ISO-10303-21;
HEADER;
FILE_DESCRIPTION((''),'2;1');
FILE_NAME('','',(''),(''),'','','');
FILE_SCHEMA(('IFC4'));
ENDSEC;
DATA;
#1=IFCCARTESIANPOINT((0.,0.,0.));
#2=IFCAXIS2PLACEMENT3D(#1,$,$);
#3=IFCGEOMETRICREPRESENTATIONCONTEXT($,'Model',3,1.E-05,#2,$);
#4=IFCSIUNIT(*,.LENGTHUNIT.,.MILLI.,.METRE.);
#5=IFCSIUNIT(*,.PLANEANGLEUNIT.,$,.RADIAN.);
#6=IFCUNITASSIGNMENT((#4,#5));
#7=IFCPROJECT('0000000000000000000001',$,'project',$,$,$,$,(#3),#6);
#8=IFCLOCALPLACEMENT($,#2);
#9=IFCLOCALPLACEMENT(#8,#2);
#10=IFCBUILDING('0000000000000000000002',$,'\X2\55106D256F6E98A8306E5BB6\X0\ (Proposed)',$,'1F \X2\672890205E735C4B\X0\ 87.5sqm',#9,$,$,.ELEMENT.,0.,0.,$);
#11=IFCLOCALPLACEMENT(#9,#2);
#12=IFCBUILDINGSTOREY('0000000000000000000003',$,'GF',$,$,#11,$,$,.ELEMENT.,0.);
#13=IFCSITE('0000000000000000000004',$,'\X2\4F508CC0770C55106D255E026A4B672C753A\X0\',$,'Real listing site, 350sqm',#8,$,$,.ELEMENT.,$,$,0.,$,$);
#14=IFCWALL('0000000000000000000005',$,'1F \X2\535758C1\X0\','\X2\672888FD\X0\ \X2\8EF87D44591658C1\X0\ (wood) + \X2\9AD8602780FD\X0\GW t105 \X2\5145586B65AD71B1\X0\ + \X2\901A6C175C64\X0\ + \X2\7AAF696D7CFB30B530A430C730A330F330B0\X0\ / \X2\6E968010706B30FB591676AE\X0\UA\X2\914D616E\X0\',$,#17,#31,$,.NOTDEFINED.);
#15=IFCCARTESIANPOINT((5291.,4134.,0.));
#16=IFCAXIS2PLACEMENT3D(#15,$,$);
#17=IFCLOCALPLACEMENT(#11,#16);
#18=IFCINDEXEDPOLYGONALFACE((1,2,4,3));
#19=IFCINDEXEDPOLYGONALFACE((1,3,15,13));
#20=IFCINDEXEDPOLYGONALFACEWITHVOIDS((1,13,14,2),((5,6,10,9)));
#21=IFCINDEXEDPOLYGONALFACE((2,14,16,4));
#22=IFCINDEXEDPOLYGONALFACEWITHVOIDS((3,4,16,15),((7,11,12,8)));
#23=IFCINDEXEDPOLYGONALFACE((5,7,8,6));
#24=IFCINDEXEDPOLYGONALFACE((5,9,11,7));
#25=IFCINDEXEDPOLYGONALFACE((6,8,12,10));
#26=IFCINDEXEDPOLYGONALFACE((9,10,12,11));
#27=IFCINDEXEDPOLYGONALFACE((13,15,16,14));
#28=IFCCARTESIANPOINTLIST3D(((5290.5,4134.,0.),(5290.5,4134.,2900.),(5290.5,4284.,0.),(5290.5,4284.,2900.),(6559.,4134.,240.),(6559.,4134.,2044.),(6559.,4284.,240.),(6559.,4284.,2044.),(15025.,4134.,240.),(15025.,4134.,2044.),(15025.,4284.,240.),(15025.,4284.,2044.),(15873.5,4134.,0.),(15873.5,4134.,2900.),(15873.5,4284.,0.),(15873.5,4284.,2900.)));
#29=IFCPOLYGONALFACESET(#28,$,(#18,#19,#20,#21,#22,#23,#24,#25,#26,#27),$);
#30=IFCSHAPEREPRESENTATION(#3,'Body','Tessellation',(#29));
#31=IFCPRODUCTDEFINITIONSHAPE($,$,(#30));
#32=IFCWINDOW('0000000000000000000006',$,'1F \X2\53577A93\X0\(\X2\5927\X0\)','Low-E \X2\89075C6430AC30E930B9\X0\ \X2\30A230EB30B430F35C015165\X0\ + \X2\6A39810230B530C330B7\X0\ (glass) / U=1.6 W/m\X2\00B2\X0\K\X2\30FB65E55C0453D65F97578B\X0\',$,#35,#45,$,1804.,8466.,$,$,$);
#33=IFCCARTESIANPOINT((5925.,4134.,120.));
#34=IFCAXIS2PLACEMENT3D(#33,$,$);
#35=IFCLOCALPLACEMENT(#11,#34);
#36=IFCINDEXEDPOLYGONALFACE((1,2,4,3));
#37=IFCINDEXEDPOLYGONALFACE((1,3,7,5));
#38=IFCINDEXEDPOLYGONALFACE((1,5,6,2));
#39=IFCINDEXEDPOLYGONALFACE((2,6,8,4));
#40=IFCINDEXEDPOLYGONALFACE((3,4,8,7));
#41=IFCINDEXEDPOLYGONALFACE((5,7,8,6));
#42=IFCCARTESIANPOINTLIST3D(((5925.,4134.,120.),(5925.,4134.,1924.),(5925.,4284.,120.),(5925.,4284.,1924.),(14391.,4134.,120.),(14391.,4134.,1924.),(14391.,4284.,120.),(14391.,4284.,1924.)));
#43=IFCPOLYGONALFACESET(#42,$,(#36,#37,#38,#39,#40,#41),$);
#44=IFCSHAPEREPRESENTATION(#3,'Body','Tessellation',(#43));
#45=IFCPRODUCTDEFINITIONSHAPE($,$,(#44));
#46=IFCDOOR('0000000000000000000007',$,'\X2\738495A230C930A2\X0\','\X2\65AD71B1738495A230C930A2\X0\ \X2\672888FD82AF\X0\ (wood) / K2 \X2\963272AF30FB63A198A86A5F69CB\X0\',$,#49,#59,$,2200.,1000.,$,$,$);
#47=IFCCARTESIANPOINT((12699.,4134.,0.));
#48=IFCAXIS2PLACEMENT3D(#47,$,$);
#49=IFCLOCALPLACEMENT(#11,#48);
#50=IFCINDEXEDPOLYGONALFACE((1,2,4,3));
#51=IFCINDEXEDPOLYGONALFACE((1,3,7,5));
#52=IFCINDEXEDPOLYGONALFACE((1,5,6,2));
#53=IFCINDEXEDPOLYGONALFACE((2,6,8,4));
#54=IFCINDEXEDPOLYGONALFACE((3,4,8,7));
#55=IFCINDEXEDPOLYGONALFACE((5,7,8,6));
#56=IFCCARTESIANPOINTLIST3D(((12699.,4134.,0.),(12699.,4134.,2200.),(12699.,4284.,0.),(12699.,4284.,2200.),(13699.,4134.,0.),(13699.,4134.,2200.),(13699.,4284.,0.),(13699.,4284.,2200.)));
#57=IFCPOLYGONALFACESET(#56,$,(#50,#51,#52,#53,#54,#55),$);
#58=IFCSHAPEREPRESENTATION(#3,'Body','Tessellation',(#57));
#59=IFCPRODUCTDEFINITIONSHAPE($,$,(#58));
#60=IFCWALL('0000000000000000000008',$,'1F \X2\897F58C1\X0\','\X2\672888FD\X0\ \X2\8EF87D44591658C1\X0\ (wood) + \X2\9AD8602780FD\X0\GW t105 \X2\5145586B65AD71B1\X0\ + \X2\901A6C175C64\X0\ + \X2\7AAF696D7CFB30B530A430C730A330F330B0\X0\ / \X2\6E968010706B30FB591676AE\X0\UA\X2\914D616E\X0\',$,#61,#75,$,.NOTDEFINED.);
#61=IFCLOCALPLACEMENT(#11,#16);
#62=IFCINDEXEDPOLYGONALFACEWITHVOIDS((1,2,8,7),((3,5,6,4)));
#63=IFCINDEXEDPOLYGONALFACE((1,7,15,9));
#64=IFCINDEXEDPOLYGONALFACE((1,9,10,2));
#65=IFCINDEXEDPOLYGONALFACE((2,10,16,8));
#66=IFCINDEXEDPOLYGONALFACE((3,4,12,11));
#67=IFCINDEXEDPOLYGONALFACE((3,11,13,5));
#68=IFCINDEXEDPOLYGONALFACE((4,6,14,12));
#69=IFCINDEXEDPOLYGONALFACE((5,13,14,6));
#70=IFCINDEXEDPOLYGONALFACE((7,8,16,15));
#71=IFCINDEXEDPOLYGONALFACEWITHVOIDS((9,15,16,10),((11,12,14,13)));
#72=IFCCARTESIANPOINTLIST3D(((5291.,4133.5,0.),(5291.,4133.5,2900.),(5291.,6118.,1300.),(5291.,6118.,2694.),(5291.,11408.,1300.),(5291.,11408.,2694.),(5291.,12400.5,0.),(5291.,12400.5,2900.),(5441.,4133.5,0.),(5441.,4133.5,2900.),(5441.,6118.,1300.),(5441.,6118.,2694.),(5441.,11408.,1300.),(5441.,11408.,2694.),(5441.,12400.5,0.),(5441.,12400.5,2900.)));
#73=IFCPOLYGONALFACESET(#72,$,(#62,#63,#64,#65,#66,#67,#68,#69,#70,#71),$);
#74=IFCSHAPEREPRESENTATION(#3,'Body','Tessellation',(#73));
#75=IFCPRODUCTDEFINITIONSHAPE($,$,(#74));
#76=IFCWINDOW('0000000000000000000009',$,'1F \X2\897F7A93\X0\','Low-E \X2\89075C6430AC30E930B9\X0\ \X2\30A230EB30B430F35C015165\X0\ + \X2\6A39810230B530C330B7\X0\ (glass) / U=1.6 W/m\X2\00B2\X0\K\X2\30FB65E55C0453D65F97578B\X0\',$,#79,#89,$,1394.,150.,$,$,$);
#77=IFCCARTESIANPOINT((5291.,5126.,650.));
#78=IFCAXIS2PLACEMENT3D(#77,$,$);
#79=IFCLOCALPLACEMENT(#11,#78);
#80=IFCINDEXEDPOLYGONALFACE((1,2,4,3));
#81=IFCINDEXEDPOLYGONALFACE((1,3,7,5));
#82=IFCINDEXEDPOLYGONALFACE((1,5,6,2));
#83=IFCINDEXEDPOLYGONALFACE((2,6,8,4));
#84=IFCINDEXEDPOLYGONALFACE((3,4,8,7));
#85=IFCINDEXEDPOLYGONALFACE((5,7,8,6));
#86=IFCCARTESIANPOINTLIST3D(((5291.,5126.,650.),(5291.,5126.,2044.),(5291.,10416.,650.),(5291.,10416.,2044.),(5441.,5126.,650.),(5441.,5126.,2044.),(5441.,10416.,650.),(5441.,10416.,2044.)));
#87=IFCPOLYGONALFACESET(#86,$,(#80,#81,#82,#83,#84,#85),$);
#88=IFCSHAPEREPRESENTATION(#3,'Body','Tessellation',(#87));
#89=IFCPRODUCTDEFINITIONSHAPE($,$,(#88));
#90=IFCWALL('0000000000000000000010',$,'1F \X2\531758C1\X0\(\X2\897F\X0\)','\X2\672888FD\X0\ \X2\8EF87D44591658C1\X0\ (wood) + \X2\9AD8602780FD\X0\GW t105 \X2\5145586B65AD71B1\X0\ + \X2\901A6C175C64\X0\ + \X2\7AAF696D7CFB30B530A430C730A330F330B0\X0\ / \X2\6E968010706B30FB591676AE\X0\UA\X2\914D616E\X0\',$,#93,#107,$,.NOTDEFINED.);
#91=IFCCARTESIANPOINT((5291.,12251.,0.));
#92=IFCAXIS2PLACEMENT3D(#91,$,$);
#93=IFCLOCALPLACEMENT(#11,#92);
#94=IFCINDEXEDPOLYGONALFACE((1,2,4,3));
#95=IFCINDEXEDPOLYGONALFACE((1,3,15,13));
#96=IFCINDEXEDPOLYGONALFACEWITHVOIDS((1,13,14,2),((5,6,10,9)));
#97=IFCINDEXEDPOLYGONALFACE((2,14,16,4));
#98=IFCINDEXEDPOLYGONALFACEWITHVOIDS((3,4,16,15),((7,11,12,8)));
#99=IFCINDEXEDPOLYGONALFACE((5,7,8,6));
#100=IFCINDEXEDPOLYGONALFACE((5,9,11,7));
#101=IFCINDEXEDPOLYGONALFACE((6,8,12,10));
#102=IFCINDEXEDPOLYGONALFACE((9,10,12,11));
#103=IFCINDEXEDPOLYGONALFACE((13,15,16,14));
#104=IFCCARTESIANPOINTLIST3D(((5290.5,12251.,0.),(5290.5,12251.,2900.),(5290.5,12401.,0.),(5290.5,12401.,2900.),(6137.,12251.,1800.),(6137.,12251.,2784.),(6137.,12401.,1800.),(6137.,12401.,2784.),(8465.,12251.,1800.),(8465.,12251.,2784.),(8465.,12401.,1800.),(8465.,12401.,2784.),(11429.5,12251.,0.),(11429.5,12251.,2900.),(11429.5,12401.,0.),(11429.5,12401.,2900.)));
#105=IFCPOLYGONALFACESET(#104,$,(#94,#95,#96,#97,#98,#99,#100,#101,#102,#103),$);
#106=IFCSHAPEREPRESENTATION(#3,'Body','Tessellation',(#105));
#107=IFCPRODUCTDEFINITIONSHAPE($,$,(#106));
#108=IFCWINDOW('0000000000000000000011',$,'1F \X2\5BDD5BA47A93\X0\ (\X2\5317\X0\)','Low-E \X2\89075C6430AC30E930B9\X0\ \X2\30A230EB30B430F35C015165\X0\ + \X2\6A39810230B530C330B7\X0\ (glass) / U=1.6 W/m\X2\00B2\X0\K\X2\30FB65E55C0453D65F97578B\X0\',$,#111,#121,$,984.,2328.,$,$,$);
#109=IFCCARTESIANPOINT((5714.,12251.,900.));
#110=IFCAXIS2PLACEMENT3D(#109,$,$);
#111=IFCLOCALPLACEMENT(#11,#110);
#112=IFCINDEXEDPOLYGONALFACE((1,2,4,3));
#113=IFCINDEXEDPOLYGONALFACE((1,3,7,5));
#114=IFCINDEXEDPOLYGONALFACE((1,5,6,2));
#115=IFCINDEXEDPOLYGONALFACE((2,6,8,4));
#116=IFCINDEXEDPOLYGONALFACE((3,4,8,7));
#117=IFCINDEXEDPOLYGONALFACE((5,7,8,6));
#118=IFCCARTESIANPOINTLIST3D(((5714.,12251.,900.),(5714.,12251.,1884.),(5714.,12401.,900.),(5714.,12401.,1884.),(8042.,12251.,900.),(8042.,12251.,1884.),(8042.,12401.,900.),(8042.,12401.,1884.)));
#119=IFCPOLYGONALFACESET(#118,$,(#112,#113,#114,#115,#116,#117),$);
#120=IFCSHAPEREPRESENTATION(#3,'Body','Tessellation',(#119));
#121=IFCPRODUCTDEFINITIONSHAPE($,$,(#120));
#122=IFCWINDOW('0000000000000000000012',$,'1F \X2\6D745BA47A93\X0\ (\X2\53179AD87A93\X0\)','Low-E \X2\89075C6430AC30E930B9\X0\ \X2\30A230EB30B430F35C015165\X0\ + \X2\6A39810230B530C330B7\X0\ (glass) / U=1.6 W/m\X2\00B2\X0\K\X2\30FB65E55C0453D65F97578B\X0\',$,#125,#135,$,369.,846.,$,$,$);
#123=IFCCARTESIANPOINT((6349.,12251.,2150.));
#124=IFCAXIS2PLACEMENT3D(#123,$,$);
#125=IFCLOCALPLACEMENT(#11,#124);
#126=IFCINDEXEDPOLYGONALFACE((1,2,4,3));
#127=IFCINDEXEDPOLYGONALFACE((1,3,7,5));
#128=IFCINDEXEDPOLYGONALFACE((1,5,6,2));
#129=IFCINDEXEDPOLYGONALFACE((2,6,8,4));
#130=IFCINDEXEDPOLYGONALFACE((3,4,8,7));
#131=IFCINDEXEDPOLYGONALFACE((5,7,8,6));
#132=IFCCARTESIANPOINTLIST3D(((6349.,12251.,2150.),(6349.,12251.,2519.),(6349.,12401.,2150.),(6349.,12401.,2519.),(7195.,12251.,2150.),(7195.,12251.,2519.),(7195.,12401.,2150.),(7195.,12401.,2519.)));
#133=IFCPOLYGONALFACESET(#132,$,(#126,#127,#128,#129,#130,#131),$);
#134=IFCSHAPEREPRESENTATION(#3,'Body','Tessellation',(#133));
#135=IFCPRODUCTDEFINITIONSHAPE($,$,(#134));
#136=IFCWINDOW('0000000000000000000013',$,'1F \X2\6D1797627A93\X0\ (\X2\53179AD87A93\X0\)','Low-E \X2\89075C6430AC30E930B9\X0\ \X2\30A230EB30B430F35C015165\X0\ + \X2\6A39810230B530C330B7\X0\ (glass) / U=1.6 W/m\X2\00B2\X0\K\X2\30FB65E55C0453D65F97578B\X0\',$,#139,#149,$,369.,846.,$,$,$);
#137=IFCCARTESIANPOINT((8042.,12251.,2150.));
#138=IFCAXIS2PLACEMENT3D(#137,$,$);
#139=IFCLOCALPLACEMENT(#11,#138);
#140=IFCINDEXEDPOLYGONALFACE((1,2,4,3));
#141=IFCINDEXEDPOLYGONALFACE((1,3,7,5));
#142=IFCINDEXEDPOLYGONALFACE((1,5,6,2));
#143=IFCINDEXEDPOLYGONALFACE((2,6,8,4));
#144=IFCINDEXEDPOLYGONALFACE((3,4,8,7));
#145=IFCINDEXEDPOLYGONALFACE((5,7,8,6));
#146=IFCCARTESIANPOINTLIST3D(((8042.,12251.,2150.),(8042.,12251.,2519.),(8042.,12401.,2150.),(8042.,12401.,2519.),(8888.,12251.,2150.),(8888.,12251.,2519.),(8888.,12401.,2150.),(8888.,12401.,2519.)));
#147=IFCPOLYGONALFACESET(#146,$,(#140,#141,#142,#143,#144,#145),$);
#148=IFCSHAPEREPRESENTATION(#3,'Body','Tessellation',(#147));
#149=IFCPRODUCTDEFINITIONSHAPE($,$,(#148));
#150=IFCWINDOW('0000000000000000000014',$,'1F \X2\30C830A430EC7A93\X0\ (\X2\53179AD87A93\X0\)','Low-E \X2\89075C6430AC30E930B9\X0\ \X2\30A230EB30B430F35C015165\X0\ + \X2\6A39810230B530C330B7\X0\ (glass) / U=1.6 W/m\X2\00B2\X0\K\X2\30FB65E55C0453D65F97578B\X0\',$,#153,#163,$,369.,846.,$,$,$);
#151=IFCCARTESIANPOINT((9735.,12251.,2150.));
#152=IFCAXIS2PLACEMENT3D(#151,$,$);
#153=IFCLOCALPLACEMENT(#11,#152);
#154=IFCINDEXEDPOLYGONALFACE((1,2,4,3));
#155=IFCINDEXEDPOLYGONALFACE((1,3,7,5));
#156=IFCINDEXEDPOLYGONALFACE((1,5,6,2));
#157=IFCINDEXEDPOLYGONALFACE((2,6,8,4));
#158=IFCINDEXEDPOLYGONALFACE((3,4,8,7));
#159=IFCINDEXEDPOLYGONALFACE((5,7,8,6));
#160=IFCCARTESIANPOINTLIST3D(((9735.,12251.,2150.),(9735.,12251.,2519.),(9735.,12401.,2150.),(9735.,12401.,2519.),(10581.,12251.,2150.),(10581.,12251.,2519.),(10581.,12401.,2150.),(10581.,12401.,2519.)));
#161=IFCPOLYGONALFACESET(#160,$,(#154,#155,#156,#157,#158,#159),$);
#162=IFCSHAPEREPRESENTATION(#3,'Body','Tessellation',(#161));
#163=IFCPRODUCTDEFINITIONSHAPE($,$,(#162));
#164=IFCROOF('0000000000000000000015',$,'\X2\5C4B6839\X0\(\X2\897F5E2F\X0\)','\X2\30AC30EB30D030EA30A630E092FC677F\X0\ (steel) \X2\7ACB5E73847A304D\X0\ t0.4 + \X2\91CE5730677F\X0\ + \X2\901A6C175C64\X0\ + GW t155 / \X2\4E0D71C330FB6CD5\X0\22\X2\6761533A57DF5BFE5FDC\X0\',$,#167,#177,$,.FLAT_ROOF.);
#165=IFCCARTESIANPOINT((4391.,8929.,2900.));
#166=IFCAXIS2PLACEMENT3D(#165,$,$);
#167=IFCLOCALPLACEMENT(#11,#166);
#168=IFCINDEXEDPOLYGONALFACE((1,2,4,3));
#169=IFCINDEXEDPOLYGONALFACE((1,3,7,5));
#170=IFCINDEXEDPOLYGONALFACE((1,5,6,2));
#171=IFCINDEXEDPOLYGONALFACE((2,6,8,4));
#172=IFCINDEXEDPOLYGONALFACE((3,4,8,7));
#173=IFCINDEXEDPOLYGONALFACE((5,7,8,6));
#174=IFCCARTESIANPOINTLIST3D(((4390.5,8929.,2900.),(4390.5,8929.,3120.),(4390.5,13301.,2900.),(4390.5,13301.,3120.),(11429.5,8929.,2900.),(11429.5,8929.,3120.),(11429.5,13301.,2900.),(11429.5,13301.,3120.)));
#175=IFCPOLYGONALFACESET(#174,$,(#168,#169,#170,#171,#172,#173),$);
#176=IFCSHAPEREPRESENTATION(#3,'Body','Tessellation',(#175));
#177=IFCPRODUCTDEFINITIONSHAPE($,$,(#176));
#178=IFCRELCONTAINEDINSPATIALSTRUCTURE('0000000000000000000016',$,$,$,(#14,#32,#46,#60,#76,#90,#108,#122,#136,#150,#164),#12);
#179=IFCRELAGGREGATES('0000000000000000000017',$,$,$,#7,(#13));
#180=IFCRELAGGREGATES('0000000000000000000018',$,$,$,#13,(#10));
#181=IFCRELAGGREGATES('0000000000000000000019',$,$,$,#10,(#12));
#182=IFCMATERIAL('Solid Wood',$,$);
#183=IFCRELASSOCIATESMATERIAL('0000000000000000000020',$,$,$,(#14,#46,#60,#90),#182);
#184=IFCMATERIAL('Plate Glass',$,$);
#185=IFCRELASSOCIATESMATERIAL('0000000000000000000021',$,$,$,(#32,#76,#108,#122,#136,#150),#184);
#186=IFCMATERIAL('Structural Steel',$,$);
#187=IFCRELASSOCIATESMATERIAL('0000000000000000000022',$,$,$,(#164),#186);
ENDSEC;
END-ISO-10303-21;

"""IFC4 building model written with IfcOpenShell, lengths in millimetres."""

from ifc_helpers import new_model, si_unit, frame, frame_2d, origin, place, context, project, spatial, rectangle, extrude, material, element, fill, save


model = new_model("IFC4")

# Units and contexts
model_context = context("Model", 3, precision=1e-05, world=origin())
ifc_project = project(units=[si_unit("LENGTHUNIT", "METRE", prefix="MILLI"), si_unit("PLANEANGLEUNIT", "RADIAN")], contexts=[model_context])

# Site, building, storey
site_placement = place(None, origin())
site = spatial("IfcSite", under=ifc_project, at=site_placement, Name="佐賀県唐津市橋本町", ObjectType="Real listing site, 350sqm", CompositionType="ELEMENT", RefElevation=0.0)
building_placement = place(site_placement, origin())
building = spatial("IfcBuilding", under=site, at=building_placement, Name="唐津潮風の家 (Proposed)", ObjectType="1F 木造平屋 87.5sqm", CompositionType="ELEMENT", ElevationOfRefHeight=0.0, ElevationOfTerrain=0.0)
storey_placement = place(building_placement, origin())
storey = spatial("IfcBuildingStorey", under=building, at=storey_placement, Name="GF", CompositionType="ELEMENT", Elevation=0.0)

# Shared definitions
ifc_material_1 = material(Name="Solid Wood")

# Wall, openings, window, door
wall_1_placement = place(storey_placement, frame((5291.0, 4134.0, 0.0)))
wall_1 = element("IfcWall", 1, at=wall_1_placement, inside=storey, material=ifc_material_1, Name="1F 南壁", Description="木製 軸組外壁 (wood) + 高性能GW t105 充填断熱 + 通気層 + 窯業系サイディング / 準耐火・外皮UA配慮", PredefinedType="NOTDEFINED", context=model_context, shape_type="SweptSolid", body=[
    extrude(rectangle(XDim=10583.0, YDim=150.0, at=frame_2d((5291.0, 75.0))), frame((5291.0, 4134.0, 0.0)), (0.0, 0.0, 1.0), 2900.0),
])
opening_1_placement = place(storey_placement, frame((5925.0, 4134.0, 120.0)))
opening_1 = element("IfcOpeningElement", 2, at=opening_1_placement, cuts=wall_1, PredefinedType="NOTDEFINED", context=model_context, shape_type="SweptSolid", body=[
    extrude(rectangle(XDim=8466.0, YDim=150.0, at=frame_2d((4233.0, 75.0))), frame((5925.0, 4134.0, 120.0)), (0.0, 0.0, 1.0), 1804.0),
])
opening_2_placement = place(storey_placement, frame((12699.0, 4134.0, 0.0)))
opening_2 = element("IfcOpeningElement", 3, at=opening_2_placement, cuts=wall_1, PredefinedType="NOTDEFINED", context=model_context, shape_type="SweptSolid", body=[
    extrude(rectangle(XDim=1000.0, YDim=150.0, at=frame_2d((500.0, 75.0))), frame((12699.0, 4134.0, 0.0)), (0.0, 0.0, 1.0), 2200.0),
])
ifc_material_2 = material(Name="Plate Glass")
window_1_placement = place(storey_placement, frame((5925.0, 4134.0, 120.0)))
window_1 = element("IfcWindow", 4, at=window_1_placement, inside=storey, material=ifc_material_2, Name="1F 南窓(大)", Description="Low-E 複層ガラス アルゴン封入 + 樹脂サッシ (glass) / U=1.6 W/m²K・日射取得型", OverallHeight=1804.0, OverallWidth=8466.0, context=model_context, shape_type="SweptSolid", body=[
    extrude(rectangle(XDim=8466.0, YDim=150.0, at=frame_2d((4233.0, 75.0))), frame((5925.0, 4134.0, 120.0)), (0.0, 0.0, 1.0), 1804.0),
])
fill(opening_1, window_1)
door_1_placement = place(storey_placement, frame((12699.0, 4134.0, 0.0)))
door_1 = element("IfcDoor", 5, at=door_1_placement, inside=storey, material=ifc_material_1, Name="玄関ドア", Description="断熱玄関ドア 木製芯 (wood) / K2 防犯・採風機構", OverallHeight=2200.0, OverallWidth=1000.0, context=model_context, shape_type="SweptSolid", body=[
    extrude(rectangle(XDim=1000.0, YDim=150.0, at=frame_2d((500.0, 75.0))), frame((12699.0, 4134.0, 0.0)), (0.0, 0.0, 1.0), 2200.0),
])
fill(opening_2, door_1)

# Wall, opening, window
wall_2_placement = place(storey_placement, frame((5291.0, 4134.0, 0.0)))
wall_2 = element("IfcWall", 6, at=wall_2_placement, inside=storey, material=ifc_material_1, Name="1F 西壁", Description="木製 軸組外壁 (wood) + 高性能GW t105 充填断熱 + 通気層 + 窯業系サイディング / 準耐火・外皮UA配慮", PredefinedType="NOTDEFINED", context=model_context, shape_type="SweptSolid", body=[
    extrude(rectangle(XDim=150.0, YDim=8267.0, at=frame_2d((75.0, 4133.0))), frame((5291.0, 4134.0, 0.0)), (0.0, 0.0, 1.0), 2900.0),
])
opening_3_placement = place(storey_placement, frame((5291.0, 5126.0, 650.0)))
opening_3 = element("IfcOpeningElement", 7, at=opening_3_placement, cuts=wall_2, PredefinedType="NOTDEFINED", context=model_context, shape_type="SweptSolid", body=[
    extrude(rectangle(XDim=150.0, YDim=5290.0, at=frame_2d((75.0, 2645.0))), frame((5291.0, 5126.0, 650.0)), (0.0, 0.0, 1.0), 1394.0),
])
window_2_placement = place(storey_placement, frame((5291.0, 5126.0, 650.0)))
window_2 = element("IfcWindow", 8, at=window_2_placement, inside=storey, material=ifc_material_2, Name="1F 西窓", Description="Low-E 複層ガラス アルゴン封入 + 樹脂サッシ (glass) / U=1.6 W/m²K・日射取得型", OverallHeight=1394.0, OverallWidth=150.0, context=model_context, shape_type="SweptSolid", body=[
    extrude(rectangle(XDim=150.0, YDim=5290.0, at=frame_2d((75.0, 2645.0))), frame((5291.0, 5126.0, 650.0)), (0.0, 0.0, 1.0), 1394.0),
])
fill(opening_3, window_2)

# Wall, openings, windows
wall_3_placement = place(storey_placement, frame((5291.0, 12251.0, 0.0)))
wall_3 = element("IfcWall", 9, at=wall_3_placement, inside=storey, material=ifc_material_1, Name="1F 北壁(西)", Description="木製 軸組外壁 (wood) + 高性能GW t105 充填断熱 + 通気層 + 窯業系サイディング / 準耐火・外皮UA配慮", PredefinedType="NOTDEFINED", context=model_context, shape_type="SweptSolid", body=[
    extrude(rectangle(XDim=6139.0, YDim=150.0, at=frame_2d((3069.0, 75.0))), frame((5291.0, 12251.0, 0.0)), (0.0, 0.0, 1.0), 2900.0),
])
opening_4_placement = place(storey_placement, frame((5714.0, 12251.0, 900.0)))
opening_4 = element("IfcOpeningElement", 10, at=opening_4_placement, cuts=wall_3, PredefinedType="NOTDEFINED", context=model_context, shape_type="SweptSolid", body=[
    extrude(rectangle(XDim=2328.0, YDim=150.0, at=frame_2d((1164.0, 75.0))), frame((5714.0, 12251.0, 900.0)), (0.0, 0.0, 1.0), 984.0),
])
opening_5_placement = place(storey_placement, frame((6349.0, 12251.0, 2150.0)))
opening_5 = element("IfcOpeningElement", 11, at=opening_5_placement, cuts=wall_3, PredefinedType="NOTDEFINED", context=model_context, shape_type="SweptSolid", body=[
    extrude(rectangle(XDim=846.0, YDim=150.0, at=frame_2d((423.0, 75.0))), frame((6349.0, 12251.0, 2150.0)), (0.0, 0.0, 1.0), 369.0),
])
opening_6_placement = place(storey_placement, frame((8042.0, 12251.0, 2150.0)))
opening_6 = element("IfcOpeningElement", 12, at=opening_6_placement, cuts=wall_3, PredefinedType="NOTDEFINED", context=model_context, shape_type="SweptSolid", body=[
    extrude(rectangle(XDim=846.0, YDim=150.0, at=frame_2d((423.0, 75.0))), frame((8042.0, 12251.0, 2150.0)), (0.0, 0.0, 1.0), 369.0),
])
opening_7_placement = place(storey_placement, frame((9735.0, 12251.0, 2150.0)))
opening_7 = element("IfcOpeningElement", 13, at=opening_7_placement, cuts=wall_3, PredefinedType="NOTDEFINED", context=model_context, shape_type="SweptSolid", body=[
    extrude(rectangle(XDim=846.0, YDim=150.0, at=frame_2d((423.0, 75.0))), frame((9735.0, 12251.0, 2150.0)), (0.0, 0.0, 1.0), 369.0),
])
window_3_placement = place(storey_placement, frame((5714.0, 12251.0, 900.0)))
window_3 = element("IfcWindow", 14, at=window_3_placement, inside=storey, material=ifc_material_2, Name="1F 寝室窓 (北)", Description="Low-E 複層ガラス アルゴン封入 + 樹脂サッシ (glass) / U=1.6 W/m²K・日射取得型", OverallHeight=984.0, OverallWidth=2328.0, context=model_context, shape_type="SweptSolid", body=[
    extrude(rectangle(XDim=2328.0, YDim=150.0, at=frame_2d((1164.0, 75.0))), frame((5714.0, 12251.0, 900.0)), (0.0, 0.0, 1.0), 984.0),
])
fill(opening_4, window_3)
window_4_placement = place(storey_placement, frame((6349.0, 12251.0, 2150.0)))
window_4 = element("IfcWindow", 15, at=window_4_placement, inside=storey, material=ifc_material_2, Name="1F 浴室窓 (北高窓)", Description="Low-E 複層ガラス アルゴン封入 + 樹脂サッシ (glass) / U=1.6 W/m²K・日射取得型", OverallHeight=369.0, OverallWidth=846.0, context=model_context, shape_type="SweptSolid", body=[
    extrude(rectangle(XDim=846.0, YDim=150.0, at=frame_2d((423.0, 75.0))), frame((6349.0, 12251.0, 2150.0)), (0.0, 0.0, 1.0), 369.0),
])
fill(opening_5, window_4)
window_5_placement = place(storey_placement, frame((8042.0, 12251.0, 2150.0)))
window_5 = element("IfcWindow", 16, at=window_5_placement, inside=storey, material=ifc_material_2, Name="1F 洗面窓 (北高窓)", Description="Low-E 複層ガラス アルゴン封入 + 樹脂サッシ (glass) / U=1.6 W/m²K・日射取得型", OverallHeight=369.0, OverallWidth=846.0, context=model_context, shape_type="SweptSolid", body=[
    extrude(rectangle(XDim=846.0, YDim=150.0, at=frame_2d((423.0, 75.0))), frame((8042.0, 12251.0, 2150.0)), (0.0, 0.0, 1.0), 369.0),
])
fill(opening_6, window_5)
window_6_placement = place(storey_placement, frame((9735.0, 12251.0, 2150.0)))
window_6 = element("IfcWindow", 17, at=window_6_placement, inside=storey, material=ifc_material_2, Name="1F トイレ窓 (北高窓)", Description="Low-E 複層ガラス アルゴン封入 + 樹脂サッシ (glass) / U=1.6 W/m²K・日射取得型", OverallHeight=369.0, OverallWidth=846.0, context=model_context, shape_type="SweptSolid", body=[
    extrude(rectangle(XDim=846.0, YDim=150.0, at=frame_2d((423.0, 75.0))), frame((9735.0, 12251.0, 2150.0)), (0.0, 0.0, 1.0), 369.0),
])
fill(opening_7, window_6)

# Roof
ifc_material_3 = material(Name="Structural Steel")
roof_1_placement = place(storey_placement, frame((4391.0, 8929.0, 2900.0)))
element("IfcRoof", 18, at=roof_1_placement, inside=storey, material=ifc_material_3, Name="屋根(西帯)", Description="ガルバリウム鋼板 (steel) 立平葺き t0.4 + 野地板 + 通気層 + GW t155 / 不燃・法22条区域対応", PredefinedType="FLAT_ROOF", context=model_context, shape_type="SweptSolid", body=[
    extrude(rectangle(XDim=7039.0, YDim=4372.0, at=frame_2d((3519.0, 2186.0))), frame((4391.0, 8929.0, 2900.0)), (0.0, 0.0, 1.0), 220.0),
])

save(model, "model.ifc")
